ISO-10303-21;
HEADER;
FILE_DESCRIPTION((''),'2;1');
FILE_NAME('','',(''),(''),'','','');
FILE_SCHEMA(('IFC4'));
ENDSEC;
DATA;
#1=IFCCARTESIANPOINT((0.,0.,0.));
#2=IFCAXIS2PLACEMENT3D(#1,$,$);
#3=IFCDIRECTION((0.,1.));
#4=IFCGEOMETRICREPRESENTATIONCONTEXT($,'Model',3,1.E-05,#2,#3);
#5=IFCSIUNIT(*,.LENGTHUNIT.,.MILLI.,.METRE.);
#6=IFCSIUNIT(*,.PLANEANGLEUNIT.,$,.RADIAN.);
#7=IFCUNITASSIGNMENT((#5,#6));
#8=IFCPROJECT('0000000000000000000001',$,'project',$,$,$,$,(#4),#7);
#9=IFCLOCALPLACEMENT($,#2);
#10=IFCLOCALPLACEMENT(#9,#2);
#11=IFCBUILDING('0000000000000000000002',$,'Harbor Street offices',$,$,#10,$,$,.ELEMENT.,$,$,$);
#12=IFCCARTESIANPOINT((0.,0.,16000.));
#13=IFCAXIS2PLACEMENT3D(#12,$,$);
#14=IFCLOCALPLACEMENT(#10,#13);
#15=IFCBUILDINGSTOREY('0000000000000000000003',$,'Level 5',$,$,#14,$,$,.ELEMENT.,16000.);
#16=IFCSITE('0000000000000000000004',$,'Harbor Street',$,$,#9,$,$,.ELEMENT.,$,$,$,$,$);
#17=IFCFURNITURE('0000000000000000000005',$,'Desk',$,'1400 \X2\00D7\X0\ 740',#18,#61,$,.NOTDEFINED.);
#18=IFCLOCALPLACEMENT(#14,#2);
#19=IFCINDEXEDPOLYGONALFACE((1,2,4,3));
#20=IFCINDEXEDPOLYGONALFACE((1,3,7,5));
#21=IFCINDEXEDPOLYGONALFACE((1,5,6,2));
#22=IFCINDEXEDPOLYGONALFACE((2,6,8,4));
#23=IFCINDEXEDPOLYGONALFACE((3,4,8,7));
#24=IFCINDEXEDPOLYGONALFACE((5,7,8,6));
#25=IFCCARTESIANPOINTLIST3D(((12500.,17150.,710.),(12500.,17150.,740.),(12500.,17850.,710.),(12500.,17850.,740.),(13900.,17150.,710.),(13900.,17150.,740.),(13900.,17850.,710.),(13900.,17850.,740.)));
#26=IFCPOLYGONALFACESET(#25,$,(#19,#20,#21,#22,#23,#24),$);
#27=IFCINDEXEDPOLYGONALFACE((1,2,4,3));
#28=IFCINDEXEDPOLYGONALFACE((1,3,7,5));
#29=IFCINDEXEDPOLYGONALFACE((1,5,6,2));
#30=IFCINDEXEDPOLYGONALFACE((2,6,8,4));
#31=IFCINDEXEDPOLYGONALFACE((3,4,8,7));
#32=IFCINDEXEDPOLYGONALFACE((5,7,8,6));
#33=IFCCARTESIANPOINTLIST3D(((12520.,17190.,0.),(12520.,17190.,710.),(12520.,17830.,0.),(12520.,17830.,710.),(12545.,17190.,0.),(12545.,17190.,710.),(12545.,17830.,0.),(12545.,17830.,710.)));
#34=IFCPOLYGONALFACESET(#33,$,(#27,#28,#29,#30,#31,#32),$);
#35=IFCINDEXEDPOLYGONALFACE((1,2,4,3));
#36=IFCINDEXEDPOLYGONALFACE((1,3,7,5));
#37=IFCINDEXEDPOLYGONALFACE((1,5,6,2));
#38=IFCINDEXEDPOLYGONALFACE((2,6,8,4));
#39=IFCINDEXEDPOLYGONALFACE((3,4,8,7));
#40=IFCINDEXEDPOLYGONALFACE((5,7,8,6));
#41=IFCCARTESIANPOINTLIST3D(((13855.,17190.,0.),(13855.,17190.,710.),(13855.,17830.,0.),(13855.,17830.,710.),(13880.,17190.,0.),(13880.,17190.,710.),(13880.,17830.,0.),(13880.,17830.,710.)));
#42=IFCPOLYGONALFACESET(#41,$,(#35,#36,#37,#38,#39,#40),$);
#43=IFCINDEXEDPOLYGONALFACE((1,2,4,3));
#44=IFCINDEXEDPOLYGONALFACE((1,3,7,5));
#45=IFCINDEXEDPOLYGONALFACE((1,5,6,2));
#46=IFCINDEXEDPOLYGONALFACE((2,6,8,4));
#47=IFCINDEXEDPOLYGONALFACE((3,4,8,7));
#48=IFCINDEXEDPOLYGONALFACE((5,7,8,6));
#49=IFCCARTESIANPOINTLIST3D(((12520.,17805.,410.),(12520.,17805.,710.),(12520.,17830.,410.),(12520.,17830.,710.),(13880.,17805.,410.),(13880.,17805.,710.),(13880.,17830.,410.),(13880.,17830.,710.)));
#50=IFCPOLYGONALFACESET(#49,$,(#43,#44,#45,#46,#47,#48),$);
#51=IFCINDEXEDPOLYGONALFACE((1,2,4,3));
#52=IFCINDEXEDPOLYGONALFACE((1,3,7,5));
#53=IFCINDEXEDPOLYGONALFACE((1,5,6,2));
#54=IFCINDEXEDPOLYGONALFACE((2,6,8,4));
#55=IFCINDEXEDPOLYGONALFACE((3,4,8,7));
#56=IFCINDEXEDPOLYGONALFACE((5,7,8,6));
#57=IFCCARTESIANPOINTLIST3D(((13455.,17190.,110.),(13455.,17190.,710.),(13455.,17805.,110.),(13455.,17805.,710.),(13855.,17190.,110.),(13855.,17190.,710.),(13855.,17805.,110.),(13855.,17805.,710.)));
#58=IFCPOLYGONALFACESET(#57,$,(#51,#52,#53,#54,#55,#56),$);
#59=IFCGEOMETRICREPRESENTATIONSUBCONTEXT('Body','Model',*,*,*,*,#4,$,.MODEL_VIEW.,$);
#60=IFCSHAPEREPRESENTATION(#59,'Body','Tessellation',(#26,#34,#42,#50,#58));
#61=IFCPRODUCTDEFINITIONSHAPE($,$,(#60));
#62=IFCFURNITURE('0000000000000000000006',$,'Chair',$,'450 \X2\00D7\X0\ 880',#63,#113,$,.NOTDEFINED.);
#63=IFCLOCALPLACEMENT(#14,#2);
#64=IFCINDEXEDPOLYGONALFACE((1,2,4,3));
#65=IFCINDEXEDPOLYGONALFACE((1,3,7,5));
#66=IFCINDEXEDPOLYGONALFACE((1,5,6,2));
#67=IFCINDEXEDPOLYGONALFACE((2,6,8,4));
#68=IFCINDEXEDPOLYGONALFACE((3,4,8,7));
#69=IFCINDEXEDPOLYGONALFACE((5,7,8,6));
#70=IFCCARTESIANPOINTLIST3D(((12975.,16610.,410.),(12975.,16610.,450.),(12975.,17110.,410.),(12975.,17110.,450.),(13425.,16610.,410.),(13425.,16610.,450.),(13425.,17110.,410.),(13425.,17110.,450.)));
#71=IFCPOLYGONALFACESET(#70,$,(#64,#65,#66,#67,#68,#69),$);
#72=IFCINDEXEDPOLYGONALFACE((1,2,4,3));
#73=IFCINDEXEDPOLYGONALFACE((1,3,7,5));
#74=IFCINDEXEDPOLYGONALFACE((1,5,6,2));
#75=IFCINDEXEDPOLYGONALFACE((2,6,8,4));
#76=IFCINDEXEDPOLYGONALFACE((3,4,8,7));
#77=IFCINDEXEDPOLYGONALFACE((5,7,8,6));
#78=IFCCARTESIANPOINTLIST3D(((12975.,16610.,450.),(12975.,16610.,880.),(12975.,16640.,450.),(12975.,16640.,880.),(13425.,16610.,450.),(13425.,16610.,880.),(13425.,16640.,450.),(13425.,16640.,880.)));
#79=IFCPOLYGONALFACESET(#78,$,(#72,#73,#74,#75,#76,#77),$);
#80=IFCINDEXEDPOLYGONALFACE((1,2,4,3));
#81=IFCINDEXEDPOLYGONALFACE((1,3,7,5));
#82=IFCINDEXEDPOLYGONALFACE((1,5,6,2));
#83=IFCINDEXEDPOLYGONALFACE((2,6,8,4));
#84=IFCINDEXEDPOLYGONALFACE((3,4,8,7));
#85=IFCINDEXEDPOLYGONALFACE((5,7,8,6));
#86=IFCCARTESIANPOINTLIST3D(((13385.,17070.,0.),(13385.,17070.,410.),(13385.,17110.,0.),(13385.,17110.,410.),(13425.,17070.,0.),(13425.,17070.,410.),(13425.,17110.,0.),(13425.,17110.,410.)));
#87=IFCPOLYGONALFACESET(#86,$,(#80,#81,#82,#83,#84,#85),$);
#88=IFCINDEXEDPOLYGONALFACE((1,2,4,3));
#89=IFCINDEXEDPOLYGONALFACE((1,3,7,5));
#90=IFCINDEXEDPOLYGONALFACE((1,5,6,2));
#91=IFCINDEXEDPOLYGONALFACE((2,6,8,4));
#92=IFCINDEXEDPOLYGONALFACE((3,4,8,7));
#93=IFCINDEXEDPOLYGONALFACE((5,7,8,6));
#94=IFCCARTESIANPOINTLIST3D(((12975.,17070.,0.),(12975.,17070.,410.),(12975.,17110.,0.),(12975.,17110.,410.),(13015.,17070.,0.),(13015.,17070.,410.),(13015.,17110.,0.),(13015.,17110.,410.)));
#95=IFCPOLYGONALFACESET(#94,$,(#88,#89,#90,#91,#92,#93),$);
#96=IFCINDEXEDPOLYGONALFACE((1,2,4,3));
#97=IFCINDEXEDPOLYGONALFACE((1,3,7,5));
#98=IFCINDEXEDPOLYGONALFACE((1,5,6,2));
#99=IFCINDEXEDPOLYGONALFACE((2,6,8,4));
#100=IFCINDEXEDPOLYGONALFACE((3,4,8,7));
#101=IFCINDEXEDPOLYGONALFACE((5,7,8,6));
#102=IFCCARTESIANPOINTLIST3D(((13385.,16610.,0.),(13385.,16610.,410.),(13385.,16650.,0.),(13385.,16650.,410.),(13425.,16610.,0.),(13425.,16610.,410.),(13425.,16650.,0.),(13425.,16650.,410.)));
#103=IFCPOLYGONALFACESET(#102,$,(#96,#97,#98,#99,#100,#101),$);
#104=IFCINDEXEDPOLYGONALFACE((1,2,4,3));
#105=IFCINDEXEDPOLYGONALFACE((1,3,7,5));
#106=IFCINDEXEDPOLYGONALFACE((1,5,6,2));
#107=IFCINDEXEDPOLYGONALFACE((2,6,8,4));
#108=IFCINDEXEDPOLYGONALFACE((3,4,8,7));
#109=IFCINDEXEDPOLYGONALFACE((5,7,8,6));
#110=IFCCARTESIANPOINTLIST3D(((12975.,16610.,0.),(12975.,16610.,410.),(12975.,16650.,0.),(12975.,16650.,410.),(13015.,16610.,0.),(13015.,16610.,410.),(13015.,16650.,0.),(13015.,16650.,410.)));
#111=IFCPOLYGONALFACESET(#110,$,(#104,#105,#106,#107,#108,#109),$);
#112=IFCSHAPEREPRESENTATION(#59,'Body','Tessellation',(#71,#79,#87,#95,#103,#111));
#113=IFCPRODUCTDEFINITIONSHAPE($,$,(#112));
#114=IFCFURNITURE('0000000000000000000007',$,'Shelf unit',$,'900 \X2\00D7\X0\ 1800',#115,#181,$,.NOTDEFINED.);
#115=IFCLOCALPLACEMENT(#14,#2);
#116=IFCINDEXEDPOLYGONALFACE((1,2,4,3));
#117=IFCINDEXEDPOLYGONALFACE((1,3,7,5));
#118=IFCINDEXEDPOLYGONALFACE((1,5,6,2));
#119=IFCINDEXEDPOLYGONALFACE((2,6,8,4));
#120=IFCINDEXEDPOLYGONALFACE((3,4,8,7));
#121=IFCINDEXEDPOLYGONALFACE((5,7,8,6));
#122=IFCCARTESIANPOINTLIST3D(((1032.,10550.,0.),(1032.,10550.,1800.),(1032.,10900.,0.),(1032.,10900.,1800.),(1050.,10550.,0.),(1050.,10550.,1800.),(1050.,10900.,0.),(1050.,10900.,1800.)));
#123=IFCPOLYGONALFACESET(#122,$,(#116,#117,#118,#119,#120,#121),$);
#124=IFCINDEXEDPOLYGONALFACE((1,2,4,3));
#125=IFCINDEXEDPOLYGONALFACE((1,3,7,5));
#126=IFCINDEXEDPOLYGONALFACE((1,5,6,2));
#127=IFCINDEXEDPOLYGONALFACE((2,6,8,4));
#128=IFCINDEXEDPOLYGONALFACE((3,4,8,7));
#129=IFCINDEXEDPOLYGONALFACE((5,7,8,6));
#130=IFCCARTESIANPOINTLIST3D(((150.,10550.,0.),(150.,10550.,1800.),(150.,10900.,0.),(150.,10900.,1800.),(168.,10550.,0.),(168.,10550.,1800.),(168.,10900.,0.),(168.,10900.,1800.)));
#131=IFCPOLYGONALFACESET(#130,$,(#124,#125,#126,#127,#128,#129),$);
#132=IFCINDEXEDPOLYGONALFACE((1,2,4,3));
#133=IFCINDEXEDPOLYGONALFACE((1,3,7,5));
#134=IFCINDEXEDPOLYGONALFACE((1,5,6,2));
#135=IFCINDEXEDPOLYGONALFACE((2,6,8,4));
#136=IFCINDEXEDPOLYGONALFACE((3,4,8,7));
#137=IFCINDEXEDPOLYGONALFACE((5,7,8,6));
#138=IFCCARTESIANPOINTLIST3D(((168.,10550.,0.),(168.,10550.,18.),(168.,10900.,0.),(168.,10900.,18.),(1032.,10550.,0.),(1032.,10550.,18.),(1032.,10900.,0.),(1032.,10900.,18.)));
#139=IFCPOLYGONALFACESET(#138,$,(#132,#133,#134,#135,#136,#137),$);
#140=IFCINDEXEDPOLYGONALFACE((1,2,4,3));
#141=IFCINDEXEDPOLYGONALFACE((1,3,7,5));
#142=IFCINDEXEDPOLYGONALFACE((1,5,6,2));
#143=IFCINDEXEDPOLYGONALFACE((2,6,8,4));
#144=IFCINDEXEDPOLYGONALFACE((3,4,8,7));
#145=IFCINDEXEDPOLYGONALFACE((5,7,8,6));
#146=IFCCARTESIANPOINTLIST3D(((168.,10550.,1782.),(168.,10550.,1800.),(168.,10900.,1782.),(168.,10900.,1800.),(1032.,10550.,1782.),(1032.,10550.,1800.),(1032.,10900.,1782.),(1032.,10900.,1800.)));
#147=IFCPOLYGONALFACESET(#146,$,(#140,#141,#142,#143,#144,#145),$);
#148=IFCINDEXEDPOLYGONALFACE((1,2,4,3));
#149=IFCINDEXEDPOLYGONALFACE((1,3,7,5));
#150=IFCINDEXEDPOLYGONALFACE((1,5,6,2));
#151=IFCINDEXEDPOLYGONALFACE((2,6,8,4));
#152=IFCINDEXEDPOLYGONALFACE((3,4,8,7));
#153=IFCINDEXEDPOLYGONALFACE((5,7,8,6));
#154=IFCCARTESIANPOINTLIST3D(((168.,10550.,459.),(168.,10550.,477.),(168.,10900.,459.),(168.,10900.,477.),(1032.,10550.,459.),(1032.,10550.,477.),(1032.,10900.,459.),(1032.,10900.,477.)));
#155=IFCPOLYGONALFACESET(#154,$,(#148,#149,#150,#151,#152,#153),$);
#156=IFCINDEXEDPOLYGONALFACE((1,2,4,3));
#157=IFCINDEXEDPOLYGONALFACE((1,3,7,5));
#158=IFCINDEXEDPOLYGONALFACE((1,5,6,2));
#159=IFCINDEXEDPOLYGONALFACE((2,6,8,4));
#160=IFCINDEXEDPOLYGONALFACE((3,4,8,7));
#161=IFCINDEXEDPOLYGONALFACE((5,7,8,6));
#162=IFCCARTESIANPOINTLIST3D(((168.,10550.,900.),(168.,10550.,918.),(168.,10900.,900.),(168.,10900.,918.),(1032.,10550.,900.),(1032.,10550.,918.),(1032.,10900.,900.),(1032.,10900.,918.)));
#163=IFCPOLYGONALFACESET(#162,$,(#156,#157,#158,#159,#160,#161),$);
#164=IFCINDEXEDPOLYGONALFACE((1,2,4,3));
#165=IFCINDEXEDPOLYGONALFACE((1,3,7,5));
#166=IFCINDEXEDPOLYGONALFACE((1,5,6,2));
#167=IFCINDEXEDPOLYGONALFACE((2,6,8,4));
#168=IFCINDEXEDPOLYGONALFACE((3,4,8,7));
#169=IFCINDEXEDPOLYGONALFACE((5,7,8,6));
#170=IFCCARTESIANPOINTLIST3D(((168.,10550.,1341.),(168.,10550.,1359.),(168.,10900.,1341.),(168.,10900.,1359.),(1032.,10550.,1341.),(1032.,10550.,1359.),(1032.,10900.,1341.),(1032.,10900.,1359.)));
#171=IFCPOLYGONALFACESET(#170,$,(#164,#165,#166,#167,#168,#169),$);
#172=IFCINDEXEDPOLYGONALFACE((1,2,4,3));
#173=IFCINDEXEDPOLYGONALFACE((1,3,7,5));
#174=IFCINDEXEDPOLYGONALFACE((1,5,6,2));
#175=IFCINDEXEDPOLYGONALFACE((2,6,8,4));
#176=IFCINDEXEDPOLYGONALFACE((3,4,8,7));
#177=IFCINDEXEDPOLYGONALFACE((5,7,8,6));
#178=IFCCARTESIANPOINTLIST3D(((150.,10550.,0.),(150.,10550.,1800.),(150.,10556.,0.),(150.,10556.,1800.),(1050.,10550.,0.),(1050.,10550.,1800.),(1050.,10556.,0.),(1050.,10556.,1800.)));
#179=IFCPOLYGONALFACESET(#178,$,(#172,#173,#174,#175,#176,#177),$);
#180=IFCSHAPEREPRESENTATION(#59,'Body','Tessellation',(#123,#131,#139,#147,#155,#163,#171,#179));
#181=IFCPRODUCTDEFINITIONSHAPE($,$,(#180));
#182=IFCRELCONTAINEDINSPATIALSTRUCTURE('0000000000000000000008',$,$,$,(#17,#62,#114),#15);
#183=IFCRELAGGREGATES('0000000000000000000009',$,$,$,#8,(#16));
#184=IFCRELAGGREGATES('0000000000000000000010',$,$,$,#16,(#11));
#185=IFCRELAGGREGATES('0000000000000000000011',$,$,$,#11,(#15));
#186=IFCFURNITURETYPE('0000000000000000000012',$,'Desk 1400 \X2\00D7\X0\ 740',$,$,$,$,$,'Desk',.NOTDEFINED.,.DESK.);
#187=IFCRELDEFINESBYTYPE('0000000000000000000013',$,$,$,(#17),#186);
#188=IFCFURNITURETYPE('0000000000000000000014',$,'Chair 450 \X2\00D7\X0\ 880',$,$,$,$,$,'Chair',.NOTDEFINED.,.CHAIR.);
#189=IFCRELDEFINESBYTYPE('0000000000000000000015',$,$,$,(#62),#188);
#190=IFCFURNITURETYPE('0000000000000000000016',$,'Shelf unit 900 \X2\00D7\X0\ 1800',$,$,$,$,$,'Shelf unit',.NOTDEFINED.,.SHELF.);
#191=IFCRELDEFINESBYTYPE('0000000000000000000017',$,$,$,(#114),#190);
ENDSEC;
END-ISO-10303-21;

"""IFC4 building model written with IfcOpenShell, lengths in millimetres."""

from ifc_helpers import new_model, si_unit, direction, frame, origin, place, context, subcontext, project, spatial, polyline, outline, extrude, source, transform, mapped, type_object, type_shapes, element, save


model = new_model("IFC4")

# Units and contexts
model_context = context("Model", 3, precision=1e-05, world=origin(), true_north=direction((0.0, 1.0)))
body_context = subcontext(model_context, "Body", "Model", "MODEL_VIEW")
ifc_project = project(units=[si_unit("LENGTHUNIT", "METRE", prefix="MILLI"), si_unit("PLANEANGLEUNIT", "RADIAN")], contexts=[model_context])

# Site, building, storey
site_placement = place(None, origin())
site = spatial("IfcSite", under=ifc_project, at=site_placement, Name="Harbor Street", CompositionType="ELEMENT")
building_placement = place(site_placement, origin())
building = spatial("IfcBuilding", under=site, at=building_placement, Name="Harbor Street offices", CompositionType="ELEMENT")
storey_placement = place(building_placement, frame((0.0, 0.0, 16000.0)))
storey = spatial("IfcBuildingStorey", under=building, at=storey_placement, Name="Level 5", CompositionType="ELEMENT", Elevation=16000.0)

# Furniture
furniture_type_1 = type_object("IfcFurnitureType", Name="Desk 1400 × 740", ElementType="Desk", AssemblyPlace="NOTDEFINED", PredefinedType="DESK")
shared_shape_1 = source(origin(), body_context, "Body", "SweptSolid", [
    extrude(outline(polyline([(-700.0, 0.0), (700.0, 0.0), (700.0, 700.0), (-700.0, 700.0), (-700.0, 0.0)])), frame((0.0, 0.0, 710.0)), (0.0, 0.0, 1.0), 30.0),
    extrude(outline(polyline([(-680.0, 40.0), (-655.0, 40.0), (-655.0, 680.0), (-680.0, 680.0), (-680.0, 40.0)])), origin(), (0.0, 0.0, 1.0), 710.0),
    extrude(outline(polyline([(655.0, 40.0), (680.0, 40.0), (680.0, 680.0), (655.0, 680.0), (655.0, 40.0)])), origin(), (0.0, 0.0, 1.0), 710.0),
    extrude(outline(polyline([(-680.0, 655.0), (680.0, 655.0), (680.0, 680.0), (-680.0, 680.0), (-680.0, 655.0)])), frame((0.0, 0.0, 410.0)), (0.0, 0.0, 1.0), 300.0),
    extrude(outline(polyline([(255.0, 40.0), (655.0, 40.0), (655.0, 655.0), (255.0, 655.0), (255.0, 40.0)])), frame((0.0, 0.0, 110.0)), (0.0, 0.0, 1.0), 600.0),
])
type_shapes(furniture_type_1, [shared_shape_1])
furniture_1_placement = place(storey_placement, frame((13200.0, 17150.0, 0.0), z_axis=(0.0, 0.0, 1.0), x_axis=(1.0, 0.0, 0.0)))
element("IfcFurniture", 1, at=furniture_1_placement, inside=storey, type_object=furniture_type_1, Name="Desk", ObjectType="1400 × 740", PredefinedType="NOTDEFINED", context=body_context, shape_type="MappedRepresentation", body=[
    mapped(shared_shape_1, transform((0.0, 0.0, 0.0))),
])
furniture_type_2 = type_object("IfcFurnitureType", Name="Chair 450 × 880", ElementType="Chair", AssemblyPlace="NOTDEFINED", PredefinedType="CHAIR")
shared_shape_2 = source(origin(), body_context, "Body", "SweptSolid", [
    extrude(outline(polyline([(-225.0, 0.0), (225.0, 0.0), (225.0, 500.0), (-225.0, 500.0), (-225.0, 0.0)])), frame((0.0, 0.0, 410.0)), (0.0, 0.0, 1.0), 40.0),
    extrude(outline(polyline([(-225.0, 470.0), (225.0, 470.0), (225.0, 500.0), (-225.0, 500.0), (-225.0, 470.0)])), frame((0.0, 0.0, 450.0)), (0.0, 0.0, 1.0), 430.0),
    extrude(outline(polyline([(-225.0, 0.0), (-185.0, 0.0), (-185.0, 40.0), (-225.0, 40.0), (-225.0, 0.0)])), origin(), (0.0, 0.0, 1.0), 410.0),
    extrude(outline(polyline([(185.0, 0.0), (225.0, 0.0), (225.0, 40.0), (185.0, 40.0), (185.0, 0.0)])), origin(), (0.0, 0.0, 1.0), 410.0),
    extrude(outline(polyline([(-225.0, 460.0), (-185.0, 460.0), (-185.0, 500.0), (-225.0, 500.0), (-225.0, 460.0)])), origin(), (0.0, 0.0, 1.0), 410.0),
    extrude(outline(polyline([(185.0, 460.0), (225.0, 460.0), (225.0, 500.0), (185.0, 500.0), (185.0, 460.0)])), origin(), (0.0, 0.0, 1.0), 410.0),
])
type_shapes(furniture_type_2, [shared_shape_2])
furniture_2_placement = place(storey_placement, frame((13200.0, 17110.0, 0.0), z_axis=(0.0, 0.0, 1.0), x_axis=(-1.0, 0.0, 0.0)))
element("IfcFurniture", 2, at=furniture_2_placement, inside=storey, type_object=furniture_type_2, Name="Chair", ObjectType="450 × 880", PredefinedType="NOTDEFINED", context=body_context, shape_type="MappedRepresentation", body=[
    mapped(shared_shape_2, transform((0.0, 0.0, 0.0))),
])
furniture_type_3 = type_object("IfcFurnitureType", Name="Shelf unit 900 × 1800", ElementType="Shelf unit", AssemblyPlace="NOTDEFINED", PredefinedType="SHELF")
shared_shape_3 = source(origin(), body_context, "Body", "SweptSolid", [
    extrude(outline(polyline([(-450.0, 0.0), (-432.0, 0.0), (-432.0, 350.0), (-450.0, 350.0), (-450.0, 0.0)])), origin(), (0.0, 0.0, 1.0), 1800.0),
    extrude(outline(polyline([(432.0, 0.0), (450.0, 0.0), (450.0, 350.0), (432.0, 350.0), (432.0, 0.0)])), origin(), (0.0, 0.0, 1.0), 1800.0),
    extrude(outline(polyline([(-432.0, 0.0), (432.0, 0.0), (432.0, 350.0), (-432.0, 350.0), (-432.0, 0.0)])), origin(), (0.0, 0.0, 1.0), 18.0),
    extrude(outline(polyline([(-432.0, 0.0), (432.0, 0.0), (432.0, 350.0), (-432.0, 350.0), (-432.0, 0.0)])), frame((0.0, 0.0, 1782.0)), (0.0, 0.0, 1.0), 18.0),
    extrude(outline(polyline([(-432.0, 0.0), (432.0, 0.0), (432.0, 350.0), (-432.0, 350.0), (-432.0, 0.0)])), frame((0.0, 0.0, 459.0)), (0.0, 0.0, 1.0), 18.0),
    extrude(outline(polyline([(-432.0, 0.0), (432.0, 0.0), (432.0, 350.0), (-432.0, 350.0), (-432.0, 0.0)])), frame((0.0, 0.0, 900.0)), (0.0, 0.0, 1.0), 18.0),
    extrude(outline(polyline([(-432.0, 0.0), (432.0, 0.0), (432.0, 350.0), (-432.0, 350.0), (-432.0, 0.0)])), frame((0.0, 0.0, 1341.0)), (0.0, 0.0, 1.0), 18.0),
    extrude(outline(polyline([(-450.0, 344.0), (450.0, 344.0), (450.0, 350.0), (-450.0, 350.0), (-450.0, 344.0)])), origin(), (0.0, 0.0, 1.0), 1800.0),
])
type_shapes(furniture_type_3, [shared_shape_3])
for number, where, z_axis, x_axis, name in (
    (3, (600.0, 10900.0, 0.0), (0.0, 0.0, 1.0), (-1.0, 0.0, 0.0), "Shelf unit"),
):
    element("IfcFurniture", number, at=place(storey_placement, frame(where, z_axis=z_axis, x_axis=x_axis)), inside=storey, type_object=furniture_type_3, Name=name, ObjectType="900 × 1800", PredefinedType="NOTDEFINED", context=body_context, shape_type="MappedRepresentation", body=[
        mapped(shared_shape_3, transform((0.0, 0.0, 0.0))),
    ])

save(model, "model.ifc")
